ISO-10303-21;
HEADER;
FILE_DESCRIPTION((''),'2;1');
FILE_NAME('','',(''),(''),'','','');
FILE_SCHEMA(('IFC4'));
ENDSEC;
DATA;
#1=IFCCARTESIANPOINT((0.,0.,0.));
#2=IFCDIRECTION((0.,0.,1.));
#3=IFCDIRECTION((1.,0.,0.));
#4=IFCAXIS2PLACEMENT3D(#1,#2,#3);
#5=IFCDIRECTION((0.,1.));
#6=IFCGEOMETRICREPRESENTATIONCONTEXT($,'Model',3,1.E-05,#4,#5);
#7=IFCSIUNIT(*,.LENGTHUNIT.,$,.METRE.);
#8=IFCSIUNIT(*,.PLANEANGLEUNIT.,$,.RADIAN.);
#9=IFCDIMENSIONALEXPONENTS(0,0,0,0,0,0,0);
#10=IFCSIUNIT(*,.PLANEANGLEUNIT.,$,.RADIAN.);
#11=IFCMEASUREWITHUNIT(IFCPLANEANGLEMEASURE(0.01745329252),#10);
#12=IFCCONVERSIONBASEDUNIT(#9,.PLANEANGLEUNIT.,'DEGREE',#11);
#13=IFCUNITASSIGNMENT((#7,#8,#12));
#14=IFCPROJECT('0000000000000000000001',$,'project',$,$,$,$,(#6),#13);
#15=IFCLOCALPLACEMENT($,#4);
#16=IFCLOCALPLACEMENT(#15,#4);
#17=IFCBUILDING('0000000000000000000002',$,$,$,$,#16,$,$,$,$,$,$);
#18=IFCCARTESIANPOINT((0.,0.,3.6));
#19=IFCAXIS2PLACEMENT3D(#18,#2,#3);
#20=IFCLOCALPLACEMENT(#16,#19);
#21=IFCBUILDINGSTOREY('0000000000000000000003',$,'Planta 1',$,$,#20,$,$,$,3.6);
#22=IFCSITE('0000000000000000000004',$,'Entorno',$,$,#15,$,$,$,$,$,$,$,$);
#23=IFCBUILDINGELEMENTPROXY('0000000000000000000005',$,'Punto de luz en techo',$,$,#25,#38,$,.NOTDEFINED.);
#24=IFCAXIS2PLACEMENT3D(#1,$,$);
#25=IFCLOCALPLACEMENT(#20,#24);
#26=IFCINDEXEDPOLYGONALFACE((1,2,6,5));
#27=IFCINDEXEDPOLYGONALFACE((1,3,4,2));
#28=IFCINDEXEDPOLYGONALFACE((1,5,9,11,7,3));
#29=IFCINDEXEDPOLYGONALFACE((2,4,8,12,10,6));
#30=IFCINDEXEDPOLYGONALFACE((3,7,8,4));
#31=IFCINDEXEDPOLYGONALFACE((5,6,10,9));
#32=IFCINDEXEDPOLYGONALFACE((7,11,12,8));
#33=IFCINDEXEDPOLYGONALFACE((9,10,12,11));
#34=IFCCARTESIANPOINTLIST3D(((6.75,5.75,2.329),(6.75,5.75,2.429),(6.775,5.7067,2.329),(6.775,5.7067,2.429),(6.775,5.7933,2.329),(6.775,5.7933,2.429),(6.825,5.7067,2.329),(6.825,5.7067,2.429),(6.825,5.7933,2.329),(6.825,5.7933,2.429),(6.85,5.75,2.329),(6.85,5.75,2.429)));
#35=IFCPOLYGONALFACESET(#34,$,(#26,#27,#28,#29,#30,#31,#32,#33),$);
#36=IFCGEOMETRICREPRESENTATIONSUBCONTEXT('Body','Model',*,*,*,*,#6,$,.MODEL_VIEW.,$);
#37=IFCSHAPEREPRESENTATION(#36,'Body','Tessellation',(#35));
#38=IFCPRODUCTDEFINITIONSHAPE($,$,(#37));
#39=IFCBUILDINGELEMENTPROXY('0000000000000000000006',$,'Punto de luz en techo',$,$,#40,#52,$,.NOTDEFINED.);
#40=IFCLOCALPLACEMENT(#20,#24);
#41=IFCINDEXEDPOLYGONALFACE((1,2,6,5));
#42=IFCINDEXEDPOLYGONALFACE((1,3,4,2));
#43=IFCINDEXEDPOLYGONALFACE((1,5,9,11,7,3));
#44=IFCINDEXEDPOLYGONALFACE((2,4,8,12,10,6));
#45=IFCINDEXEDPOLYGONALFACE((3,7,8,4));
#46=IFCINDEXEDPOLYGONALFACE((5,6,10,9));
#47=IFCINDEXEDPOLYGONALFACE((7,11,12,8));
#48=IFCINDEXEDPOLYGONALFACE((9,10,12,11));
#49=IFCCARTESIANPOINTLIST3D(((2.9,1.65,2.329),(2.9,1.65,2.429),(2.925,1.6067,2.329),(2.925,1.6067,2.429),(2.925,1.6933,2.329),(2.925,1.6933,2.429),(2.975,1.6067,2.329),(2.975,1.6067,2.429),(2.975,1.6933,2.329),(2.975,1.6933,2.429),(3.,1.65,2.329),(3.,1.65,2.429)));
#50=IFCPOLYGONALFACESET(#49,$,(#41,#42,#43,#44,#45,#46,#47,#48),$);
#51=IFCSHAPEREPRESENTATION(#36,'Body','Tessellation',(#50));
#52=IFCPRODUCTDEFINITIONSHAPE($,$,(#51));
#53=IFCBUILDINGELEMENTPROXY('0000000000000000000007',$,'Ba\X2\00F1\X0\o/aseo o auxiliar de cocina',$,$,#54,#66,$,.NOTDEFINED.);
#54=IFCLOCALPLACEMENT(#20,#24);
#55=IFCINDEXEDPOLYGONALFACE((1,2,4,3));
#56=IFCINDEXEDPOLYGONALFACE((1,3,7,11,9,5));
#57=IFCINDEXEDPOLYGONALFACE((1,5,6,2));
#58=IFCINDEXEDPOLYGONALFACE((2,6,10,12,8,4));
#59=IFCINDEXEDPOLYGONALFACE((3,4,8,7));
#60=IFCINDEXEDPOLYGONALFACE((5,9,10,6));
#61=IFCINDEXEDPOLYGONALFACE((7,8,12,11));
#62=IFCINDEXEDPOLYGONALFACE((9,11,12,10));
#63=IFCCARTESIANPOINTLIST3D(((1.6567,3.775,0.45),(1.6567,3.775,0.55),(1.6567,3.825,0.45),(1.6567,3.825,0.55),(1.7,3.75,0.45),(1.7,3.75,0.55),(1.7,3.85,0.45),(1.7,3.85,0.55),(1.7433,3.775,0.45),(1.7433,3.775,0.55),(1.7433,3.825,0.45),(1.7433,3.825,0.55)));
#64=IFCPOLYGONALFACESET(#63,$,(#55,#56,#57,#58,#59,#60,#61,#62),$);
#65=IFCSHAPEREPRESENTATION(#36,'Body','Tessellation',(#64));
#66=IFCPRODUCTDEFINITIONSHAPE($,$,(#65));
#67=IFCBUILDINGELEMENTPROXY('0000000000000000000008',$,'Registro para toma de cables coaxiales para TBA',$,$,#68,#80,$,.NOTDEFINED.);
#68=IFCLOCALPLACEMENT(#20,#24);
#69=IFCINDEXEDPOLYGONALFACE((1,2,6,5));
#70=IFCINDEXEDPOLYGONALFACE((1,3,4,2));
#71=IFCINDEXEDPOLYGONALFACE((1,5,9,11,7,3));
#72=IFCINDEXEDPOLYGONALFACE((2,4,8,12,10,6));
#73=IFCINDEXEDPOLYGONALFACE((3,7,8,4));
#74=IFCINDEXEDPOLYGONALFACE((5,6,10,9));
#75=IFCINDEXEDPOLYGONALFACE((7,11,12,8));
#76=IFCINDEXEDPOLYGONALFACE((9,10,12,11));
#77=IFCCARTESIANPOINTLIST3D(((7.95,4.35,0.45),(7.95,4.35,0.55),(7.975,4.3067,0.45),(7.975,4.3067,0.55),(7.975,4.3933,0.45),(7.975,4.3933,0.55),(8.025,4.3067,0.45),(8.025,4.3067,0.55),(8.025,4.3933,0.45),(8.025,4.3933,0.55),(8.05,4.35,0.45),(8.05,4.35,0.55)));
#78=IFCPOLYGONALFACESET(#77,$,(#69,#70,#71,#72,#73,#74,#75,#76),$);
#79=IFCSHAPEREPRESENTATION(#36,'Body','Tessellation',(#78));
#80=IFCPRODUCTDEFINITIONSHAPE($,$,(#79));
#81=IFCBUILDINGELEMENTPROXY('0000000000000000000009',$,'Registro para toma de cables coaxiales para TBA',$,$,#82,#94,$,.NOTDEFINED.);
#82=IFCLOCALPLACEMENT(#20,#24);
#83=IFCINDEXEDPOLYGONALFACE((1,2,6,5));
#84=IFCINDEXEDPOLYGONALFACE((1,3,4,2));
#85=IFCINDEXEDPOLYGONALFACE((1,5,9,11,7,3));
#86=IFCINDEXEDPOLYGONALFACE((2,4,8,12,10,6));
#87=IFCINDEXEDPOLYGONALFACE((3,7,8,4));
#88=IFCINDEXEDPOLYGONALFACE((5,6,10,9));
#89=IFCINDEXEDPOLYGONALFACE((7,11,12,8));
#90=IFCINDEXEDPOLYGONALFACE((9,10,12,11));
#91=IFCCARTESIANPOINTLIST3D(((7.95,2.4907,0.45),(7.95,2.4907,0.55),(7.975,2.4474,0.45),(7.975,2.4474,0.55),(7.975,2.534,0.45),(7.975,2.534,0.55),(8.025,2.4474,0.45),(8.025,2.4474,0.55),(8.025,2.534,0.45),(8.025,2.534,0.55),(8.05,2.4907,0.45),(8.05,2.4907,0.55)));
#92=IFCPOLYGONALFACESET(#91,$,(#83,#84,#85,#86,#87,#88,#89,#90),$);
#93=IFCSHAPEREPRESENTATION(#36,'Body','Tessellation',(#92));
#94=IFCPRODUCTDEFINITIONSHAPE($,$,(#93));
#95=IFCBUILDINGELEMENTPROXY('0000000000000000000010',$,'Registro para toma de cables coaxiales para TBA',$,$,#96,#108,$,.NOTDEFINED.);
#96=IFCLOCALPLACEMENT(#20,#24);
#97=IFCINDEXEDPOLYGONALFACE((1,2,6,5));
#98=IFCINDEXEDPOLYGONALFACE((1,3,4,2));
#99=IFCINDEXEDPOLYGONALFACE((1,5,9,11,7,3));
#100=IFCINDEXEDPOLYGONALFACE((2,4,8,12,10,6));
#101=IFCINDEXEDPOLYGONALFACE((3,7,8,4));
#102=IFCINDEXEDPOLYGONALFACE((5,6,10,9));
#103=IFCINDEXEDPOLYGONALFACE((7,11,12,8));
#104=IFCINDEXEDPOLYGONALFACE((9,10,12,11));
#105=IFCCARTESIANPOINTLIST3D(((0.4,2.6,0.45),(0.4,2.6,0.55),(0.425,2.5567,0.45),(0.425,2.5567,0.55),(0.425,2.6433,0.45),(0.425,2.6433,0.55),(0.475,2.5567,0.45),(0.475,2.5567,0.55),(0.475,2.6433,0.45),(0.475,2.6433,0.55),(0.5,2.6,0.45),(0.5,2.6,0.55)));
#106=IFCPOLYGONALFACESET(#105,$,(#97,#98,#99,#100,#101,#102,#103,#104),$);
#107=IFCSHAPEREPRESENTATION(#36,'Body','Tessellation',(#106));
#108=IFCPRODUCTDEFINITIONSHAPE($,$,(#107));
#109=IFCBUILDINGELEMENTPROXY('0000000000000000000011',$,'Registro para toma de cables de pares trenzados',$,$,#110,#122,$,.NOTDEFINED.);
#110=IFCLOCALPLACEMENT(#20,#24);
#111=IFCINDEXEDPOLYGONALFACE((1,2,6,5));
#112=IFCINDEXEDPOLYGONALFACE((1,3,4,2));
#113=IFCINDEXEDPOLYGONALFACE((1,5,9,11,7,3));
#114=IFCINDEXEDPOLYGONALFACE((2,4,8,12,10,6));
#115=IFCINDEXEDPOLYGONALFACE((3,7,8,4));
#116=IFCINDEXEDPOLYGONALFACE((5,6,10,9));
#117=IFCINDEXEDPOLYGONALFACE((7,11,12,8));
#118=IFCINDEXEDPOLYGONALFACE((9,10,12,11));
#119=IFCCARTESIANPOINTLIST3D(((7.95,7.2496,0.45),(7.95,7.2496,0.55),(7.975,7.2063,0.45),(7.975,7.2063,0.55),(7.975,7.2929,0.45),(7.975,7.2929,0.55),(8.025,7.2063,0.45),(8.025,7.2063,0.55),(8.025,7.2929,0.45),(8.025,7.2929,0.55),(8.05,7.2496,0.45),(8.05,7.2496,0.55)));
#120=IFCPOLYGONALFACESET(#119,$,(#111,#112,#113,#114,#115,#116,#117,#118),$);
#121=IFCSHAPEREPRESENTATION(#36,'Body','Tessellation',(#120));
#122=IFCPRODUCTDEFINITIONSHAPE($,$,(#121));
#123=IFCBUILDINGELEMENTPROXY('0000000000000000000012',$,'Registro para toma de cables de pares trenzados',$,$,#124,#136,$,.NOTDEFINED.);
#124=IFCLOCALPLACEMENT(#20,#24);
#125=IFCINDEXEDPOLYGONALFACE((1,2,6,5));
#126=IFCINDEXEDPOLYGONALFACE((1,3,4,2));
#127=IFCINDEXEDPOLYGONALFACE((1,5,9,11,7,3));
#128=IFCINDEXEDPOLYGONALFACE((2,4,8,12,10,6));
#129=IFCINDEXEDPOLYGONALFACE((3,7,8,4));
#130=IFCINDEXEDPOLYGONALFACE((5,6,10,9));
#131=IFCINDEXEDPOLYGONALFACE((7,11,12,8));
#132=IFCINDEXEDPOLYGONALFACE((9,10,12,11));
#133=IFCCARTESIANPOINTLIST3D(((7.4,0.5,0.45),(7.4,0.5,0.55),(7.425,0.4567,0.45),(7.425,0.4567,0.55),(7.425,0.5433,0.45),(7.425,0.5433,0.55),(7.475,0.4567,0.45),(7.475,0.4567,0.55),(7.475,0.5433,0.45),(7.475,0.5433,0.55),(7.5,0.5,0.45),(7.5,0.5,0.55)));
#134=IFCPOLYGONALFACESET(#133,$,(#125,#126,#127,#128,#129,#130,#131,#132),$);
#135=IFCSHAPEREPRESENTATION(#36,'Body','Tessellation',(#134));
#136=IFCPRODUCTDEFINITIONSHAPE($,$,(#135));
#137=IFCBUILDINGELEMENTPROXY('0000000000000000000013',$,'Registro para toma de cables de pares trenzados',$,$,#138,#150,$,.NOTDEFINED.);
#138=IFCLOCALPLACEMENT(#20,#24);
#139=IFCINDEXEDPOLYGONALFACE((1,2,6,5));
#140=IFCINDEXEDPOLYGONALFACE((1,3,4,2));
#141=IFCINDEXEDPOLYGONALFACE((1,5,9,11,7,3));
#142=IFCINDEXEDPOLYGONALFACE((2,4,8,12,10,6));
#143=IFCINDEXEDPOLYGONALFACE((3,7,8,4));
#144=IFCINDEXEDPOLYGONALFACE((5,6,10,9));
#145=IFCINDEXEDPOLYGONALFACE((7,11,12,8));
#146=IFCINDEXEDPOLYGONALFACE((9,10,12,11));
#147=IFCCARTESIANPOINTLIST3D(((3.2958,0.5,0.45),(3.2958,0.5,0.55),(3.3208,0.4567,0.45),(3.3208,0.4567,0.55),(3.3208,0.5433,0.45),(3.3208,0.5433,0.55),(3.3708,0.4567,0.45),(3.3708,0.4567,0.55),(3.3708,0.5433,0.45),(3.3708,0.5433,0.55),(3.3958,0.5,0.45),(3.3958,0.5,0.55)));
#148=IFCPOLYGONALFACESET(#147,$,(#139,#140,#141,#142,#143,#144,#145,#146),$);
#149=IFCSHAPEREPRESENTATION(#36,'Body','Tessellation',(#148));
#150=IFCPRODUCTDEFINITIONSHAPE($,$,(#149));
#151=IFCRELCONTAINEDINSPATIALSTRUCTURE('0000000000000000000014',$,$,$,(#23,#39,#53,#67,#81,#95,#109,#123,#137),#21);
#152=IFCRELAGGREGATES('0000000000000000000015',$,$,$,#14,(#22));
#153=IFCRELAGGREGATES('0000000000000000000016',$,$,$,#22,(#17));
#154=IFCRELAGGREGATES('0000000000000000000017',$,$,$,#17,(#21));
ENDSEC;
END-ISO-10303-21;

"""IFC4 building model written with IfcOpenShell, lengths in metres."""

from ifc_helpers import new_model, entity, si_unit, converted_unit, direction, frame, origin_with_axes, place, context, subcontext, project, spatial, polyline, outline, extrude, source, transform, mapped, element, save


model = new_model("IFC4")

# Units and contexts
model_context = context("Model", 3, precision=1e-05, world=origin_with_axes(), true_north=direction((0.0, 1.0)))
body_context = subcontext(model_context, "Body", "Model", "MODEL_VIEW")
ifc_project = project(units=[si_unit("LENGTHUNIT", "METRE"), si_unit("PLANEANGLEUNIT", "RADIAN"), converted_unit("PLANEANGLEUNIT", "DEGREE", entity("IfcPlaneAngleMeasure", 0.01745329252), si_unit("PLANEANGLEUNIT", "RADIAN"), dimensions=[0, 0, 0, 0, 0, 0, 0])], contexts=[model_context])

# Site, building, storey
site_placement = place(None, origin_with_axes())
site = spatial("IfcSite", under=ifc_project, at=site_placement, Name="Entorno")
building_placement = place(site_placement, origin_with_axes())
building = spatial("IfcBuilding", under=site, at=building_placement)
storey_placement = place(building_placement, frame((0.0, 0.0, 3.6), z_axis=(0.0, 0.0, 1.0), x_axis=(1.0, 0.0, 0.0)))
storey = spatial("IfcBuildingStorey", under=building, at=storey_placement, Name="Planta 1", Elevation=3.6)

# Building element proxies
shared_shape_1 = source(origin_with_axes(), body_context, "Body", "SolidModel", [
    extrude(outline(polyline([(0.05, 0.0), (0.025, 0.0433), (-0.025, 0.0433), (-0.05, 0.0), (-0.025, -0.0433), (0.025, -0.0433), (0.05, 0.0)])), frame((0.0, 0.0, -0.05), z_axis=(0.0, 0.0, 1.0), x_axis=(1.0, 0.0, 0.0)), (0.0, 0.0, 1.0), 0.1),
])
proxy_1_placement = place(storey_placement, frame((0.0, 0.0, -3.6), z_axis=(0.0, 0.0, 1.0), x_axis=(1.0, 0.0, 0.0)))
element("IfcBuildingElementProxy", 1, at=proxy_1_placement, inside=storey, Name="Punto de luz en techo", PredefinedType="NOTDEFINED", context=body_context, shape_type="Brep", body=[
    mapped(shared_shape_1, transform((6.8, 5.75, 5.979), x_axis=(1.0, 0.0, 0.0), y_axis=(0.0, 1.0, 0.0), z_axis=(0.0, 0.0, 1.0))),
])
proxy_2_placement = place(storey_placement, frame((0.0, 0.0, -3.6), z_axis=(0.0, 0.0, 1.0), x_axis=(1.0, 0.0, 0.0)))
element("IfcBuildingElementProxy", 2, at=proxy_2_placement, inside=storey, Name="Punto de luz en techo", PredefinedType="NOTDEFINED", context=body_context, shape_type="Brep", body=[
    mapped(shared_shape_1, transform((2.95, 1.65, 5.979), x_axis=(1.0, 0.0, 0.0), y_axis=(0.0, 1.0, 0.0), z_axis=(0.0, 0.0, 1.0))),
])
shared_shape_2 = source(origin_with_axes(), body_context, "Body", "SolidModel", [
    extrude(outline(polyline([(0.05, 0.0), (0.025, 0.0433), (-0.025, 0.0433), (-0.05, 0.0), (-0.025, -0.0433), (0.025, -0.0433), (0.05, 0.0)])), frame((0.0, 0.0, -0.05), z_axis=(0.0, 0.0, 1.0), x_axis=(1.0, 0.0, 0.0)), (0.0, 0.0, 1.0), 0.1),
])
proxy_3_placement = place(storey_placement, frame((0.0, 0.0, -3.6), z_axis=(0.0, 0.0, 1.0), x_axis=(1.0, 0.0, 0.0)))
element("IfcBuildingElementProxy", 3, at=proxy_3_placement, inside=storey, Name="Baño/aseo o auxiliar de cocina", PredefinedType="NOTDEFINED", context=body_context, shape_type="Brep", body=[
    mapped(shared_shape_2, transform((1.7, 3.8, 4.1), x_axis=(0.0, 1.0, 0.0), y_axis=(-1.0, 0.0, 0.0), z_axis=(0.0, 0.0, 1.0))),
])
shared_shape_3 = source(origin_with_axes(), body_context, "Body", "SolidModel", [
    extrude(outline(polyline([(0.05, 0.0), (0.025, 0.0433), (-0.025, 0.0433), (-0.05, 0.0), (-0.025, -0.0433), (0.025, -0.0433), (0.05, 0.0)])), frame((0.0, 0.0, -0.05), z_axis=(0.0, 0.0, 1.0), x_axis=(1.0, 0.0, 0.0)), (0.0, 0.0, 1.0), 0.1),
])
proxy_4_placement = place(storey_placement, frame((0.0, 0.0, -3.6), z_axis=(0.0, 0.0, 1.0), x_axis=(1.0, 0.0, 0.0)))
element("IfcBuildingElementProxy", 4, at=proxy_4_placement, inside=storey, Name="Registro para toma de cables coaxiales para TBA", PredefinedType="NOTDEFINED", context=body_context, shape_type="Brep", body=[
    mapped(shared_shape_3, transform((8.0, 4.35, 4.1), x_axis=(1.0, 0.0, 0.0), y_axis=(0.0, 1.0, 0.0), z_axis=(0.0, 0.0, 1.0))),
])
proxy_5_placement = place(storey_placement, frame((0.0, 0.0, -3.6), z_axis=(0.0, 0.0, 1.0), x_axis=(1.0, 0.0, 0.0)))
element("IfcBuildingElementProxy", 5, at=proxy_5_placement, inside=storey, Name="Registro para toma de cables coaxiales para TBA", PredefinedType="NOTDEFINED", context=body_context, shape_type="Brep", body=[
    mapped(shared_shape_3, transform((8.0, 2.4907, 4.1), x_axis=(1.0, 0.0, 0.0), y_axis=(0.0, 1.0, 0.0), z_axis=(0.0, 0.0, 1.0))),
])
proxy_6_placement = place(storey_placement, frame((0.0, 0.0, -3.6), z_axis=(0.0, 0.0, 1.0), x_axis=(1.0, 0.0, 0.0)))
element("IfcBuildingElementProxy", 6, at=proxy_6_placement, inside=storey, Name="Registro para toma de cables coaxiales para TBA", PredefinedType="NOTDEFINED", context=body_context, shape_type="Brep", body=[
    mapped(shared_shape_3, transform((0.45, 2.6, 4.1), x_axis=(1.0, 0.0, 0.0), y_axis=(0.0, 1.0, 0.0), z_axis=(0.0, 0.0, 1.0))),
])
shared_shape_4 = source(origin_with_axes(), body_context, "Body", "SolidModel", [
    extrude(outline(polyline([(0.05, 0.0), (0.025, 0.0433), (-0.025, 0.0433), (-0.05, 0.0), (-0.025, -0.0433), (0.025, -0.0433), (0.05, 0.0)])), frame((0.0, 0.0, -0.05), z_axis=(0.0, 0.0, 1.0), x_axis=(1.0, 0.0, 0.0)), (0.0, 0.0, 1.0), 0.1),
])
proxy_7_placement = place(storey_placement, frame((0.0, 0.0, -3.6), z_axis=(0.0, 0.0, 1.0), x_axis=(1.0, 0.0, 0.0)))
element("IfcBuildingElementProxy", 7, at=proxy_7_placement, inside=storey, Name="Registro para toma de cables de pares trenzados", PredefinedType="NOTDEFINED", context=body_context, shape_type="Brep", body=[
    mapped(shared_shape_4, transform((8.0, 7.2496, 4.1), x_axis=(1.0, 0.0, 0.0), y_axis=(0.0, 1.0, 0.0), z_axis=(0.0, 0.0, 1.0))),
])
proxy_8_placement = place(storey_placement, frame((0.0, 0.0, -3.6), z_axis=(0.0, 0.0, 1.0), x_axis=(1.0, 0.0, 0.0)))
element("IfcBuildingElementProxy", 8, at=proxy_8_placement, inside=storey, Name="Registro para toma de cables de pares trenzados", PredefinedType="NOTDEFINED", context=body_context, shape_type="Brep", body=[
    mapped(shared_shape_4, transform((7.45, 0.5, 4.1), x_axis=(1.0, 0.0, 0.0), y_axis=(0.0, 1.0, 0.0), z_axis=(0.0, 0.0, 1.0))),
])
proxy_9_placement = place(storey_placement, frame((0.0, 0.0, -3.6), z_axis=(0.0, 0.0, 1.0), x_axis=(1.0, 0.0, 0.0)))
element("IfcBuildingElementProxy", 9, at=proxy_9_placement, inside=storey, Name="Registro para toma de cables de pares trenzados", PredefinedType="NOTDEFINED", context=body_context, shape_type="Brep", body=[
    mapped(shared_shape_4, transform((3.3458, 0.5, 4.1), x_axis=(1.0, 0.0, 0.0), y_axis=(0.0, 1.0, 0.0), z_axis=(0.0, 0.0, 1.0))),
])

save(model, "model.ifc")
